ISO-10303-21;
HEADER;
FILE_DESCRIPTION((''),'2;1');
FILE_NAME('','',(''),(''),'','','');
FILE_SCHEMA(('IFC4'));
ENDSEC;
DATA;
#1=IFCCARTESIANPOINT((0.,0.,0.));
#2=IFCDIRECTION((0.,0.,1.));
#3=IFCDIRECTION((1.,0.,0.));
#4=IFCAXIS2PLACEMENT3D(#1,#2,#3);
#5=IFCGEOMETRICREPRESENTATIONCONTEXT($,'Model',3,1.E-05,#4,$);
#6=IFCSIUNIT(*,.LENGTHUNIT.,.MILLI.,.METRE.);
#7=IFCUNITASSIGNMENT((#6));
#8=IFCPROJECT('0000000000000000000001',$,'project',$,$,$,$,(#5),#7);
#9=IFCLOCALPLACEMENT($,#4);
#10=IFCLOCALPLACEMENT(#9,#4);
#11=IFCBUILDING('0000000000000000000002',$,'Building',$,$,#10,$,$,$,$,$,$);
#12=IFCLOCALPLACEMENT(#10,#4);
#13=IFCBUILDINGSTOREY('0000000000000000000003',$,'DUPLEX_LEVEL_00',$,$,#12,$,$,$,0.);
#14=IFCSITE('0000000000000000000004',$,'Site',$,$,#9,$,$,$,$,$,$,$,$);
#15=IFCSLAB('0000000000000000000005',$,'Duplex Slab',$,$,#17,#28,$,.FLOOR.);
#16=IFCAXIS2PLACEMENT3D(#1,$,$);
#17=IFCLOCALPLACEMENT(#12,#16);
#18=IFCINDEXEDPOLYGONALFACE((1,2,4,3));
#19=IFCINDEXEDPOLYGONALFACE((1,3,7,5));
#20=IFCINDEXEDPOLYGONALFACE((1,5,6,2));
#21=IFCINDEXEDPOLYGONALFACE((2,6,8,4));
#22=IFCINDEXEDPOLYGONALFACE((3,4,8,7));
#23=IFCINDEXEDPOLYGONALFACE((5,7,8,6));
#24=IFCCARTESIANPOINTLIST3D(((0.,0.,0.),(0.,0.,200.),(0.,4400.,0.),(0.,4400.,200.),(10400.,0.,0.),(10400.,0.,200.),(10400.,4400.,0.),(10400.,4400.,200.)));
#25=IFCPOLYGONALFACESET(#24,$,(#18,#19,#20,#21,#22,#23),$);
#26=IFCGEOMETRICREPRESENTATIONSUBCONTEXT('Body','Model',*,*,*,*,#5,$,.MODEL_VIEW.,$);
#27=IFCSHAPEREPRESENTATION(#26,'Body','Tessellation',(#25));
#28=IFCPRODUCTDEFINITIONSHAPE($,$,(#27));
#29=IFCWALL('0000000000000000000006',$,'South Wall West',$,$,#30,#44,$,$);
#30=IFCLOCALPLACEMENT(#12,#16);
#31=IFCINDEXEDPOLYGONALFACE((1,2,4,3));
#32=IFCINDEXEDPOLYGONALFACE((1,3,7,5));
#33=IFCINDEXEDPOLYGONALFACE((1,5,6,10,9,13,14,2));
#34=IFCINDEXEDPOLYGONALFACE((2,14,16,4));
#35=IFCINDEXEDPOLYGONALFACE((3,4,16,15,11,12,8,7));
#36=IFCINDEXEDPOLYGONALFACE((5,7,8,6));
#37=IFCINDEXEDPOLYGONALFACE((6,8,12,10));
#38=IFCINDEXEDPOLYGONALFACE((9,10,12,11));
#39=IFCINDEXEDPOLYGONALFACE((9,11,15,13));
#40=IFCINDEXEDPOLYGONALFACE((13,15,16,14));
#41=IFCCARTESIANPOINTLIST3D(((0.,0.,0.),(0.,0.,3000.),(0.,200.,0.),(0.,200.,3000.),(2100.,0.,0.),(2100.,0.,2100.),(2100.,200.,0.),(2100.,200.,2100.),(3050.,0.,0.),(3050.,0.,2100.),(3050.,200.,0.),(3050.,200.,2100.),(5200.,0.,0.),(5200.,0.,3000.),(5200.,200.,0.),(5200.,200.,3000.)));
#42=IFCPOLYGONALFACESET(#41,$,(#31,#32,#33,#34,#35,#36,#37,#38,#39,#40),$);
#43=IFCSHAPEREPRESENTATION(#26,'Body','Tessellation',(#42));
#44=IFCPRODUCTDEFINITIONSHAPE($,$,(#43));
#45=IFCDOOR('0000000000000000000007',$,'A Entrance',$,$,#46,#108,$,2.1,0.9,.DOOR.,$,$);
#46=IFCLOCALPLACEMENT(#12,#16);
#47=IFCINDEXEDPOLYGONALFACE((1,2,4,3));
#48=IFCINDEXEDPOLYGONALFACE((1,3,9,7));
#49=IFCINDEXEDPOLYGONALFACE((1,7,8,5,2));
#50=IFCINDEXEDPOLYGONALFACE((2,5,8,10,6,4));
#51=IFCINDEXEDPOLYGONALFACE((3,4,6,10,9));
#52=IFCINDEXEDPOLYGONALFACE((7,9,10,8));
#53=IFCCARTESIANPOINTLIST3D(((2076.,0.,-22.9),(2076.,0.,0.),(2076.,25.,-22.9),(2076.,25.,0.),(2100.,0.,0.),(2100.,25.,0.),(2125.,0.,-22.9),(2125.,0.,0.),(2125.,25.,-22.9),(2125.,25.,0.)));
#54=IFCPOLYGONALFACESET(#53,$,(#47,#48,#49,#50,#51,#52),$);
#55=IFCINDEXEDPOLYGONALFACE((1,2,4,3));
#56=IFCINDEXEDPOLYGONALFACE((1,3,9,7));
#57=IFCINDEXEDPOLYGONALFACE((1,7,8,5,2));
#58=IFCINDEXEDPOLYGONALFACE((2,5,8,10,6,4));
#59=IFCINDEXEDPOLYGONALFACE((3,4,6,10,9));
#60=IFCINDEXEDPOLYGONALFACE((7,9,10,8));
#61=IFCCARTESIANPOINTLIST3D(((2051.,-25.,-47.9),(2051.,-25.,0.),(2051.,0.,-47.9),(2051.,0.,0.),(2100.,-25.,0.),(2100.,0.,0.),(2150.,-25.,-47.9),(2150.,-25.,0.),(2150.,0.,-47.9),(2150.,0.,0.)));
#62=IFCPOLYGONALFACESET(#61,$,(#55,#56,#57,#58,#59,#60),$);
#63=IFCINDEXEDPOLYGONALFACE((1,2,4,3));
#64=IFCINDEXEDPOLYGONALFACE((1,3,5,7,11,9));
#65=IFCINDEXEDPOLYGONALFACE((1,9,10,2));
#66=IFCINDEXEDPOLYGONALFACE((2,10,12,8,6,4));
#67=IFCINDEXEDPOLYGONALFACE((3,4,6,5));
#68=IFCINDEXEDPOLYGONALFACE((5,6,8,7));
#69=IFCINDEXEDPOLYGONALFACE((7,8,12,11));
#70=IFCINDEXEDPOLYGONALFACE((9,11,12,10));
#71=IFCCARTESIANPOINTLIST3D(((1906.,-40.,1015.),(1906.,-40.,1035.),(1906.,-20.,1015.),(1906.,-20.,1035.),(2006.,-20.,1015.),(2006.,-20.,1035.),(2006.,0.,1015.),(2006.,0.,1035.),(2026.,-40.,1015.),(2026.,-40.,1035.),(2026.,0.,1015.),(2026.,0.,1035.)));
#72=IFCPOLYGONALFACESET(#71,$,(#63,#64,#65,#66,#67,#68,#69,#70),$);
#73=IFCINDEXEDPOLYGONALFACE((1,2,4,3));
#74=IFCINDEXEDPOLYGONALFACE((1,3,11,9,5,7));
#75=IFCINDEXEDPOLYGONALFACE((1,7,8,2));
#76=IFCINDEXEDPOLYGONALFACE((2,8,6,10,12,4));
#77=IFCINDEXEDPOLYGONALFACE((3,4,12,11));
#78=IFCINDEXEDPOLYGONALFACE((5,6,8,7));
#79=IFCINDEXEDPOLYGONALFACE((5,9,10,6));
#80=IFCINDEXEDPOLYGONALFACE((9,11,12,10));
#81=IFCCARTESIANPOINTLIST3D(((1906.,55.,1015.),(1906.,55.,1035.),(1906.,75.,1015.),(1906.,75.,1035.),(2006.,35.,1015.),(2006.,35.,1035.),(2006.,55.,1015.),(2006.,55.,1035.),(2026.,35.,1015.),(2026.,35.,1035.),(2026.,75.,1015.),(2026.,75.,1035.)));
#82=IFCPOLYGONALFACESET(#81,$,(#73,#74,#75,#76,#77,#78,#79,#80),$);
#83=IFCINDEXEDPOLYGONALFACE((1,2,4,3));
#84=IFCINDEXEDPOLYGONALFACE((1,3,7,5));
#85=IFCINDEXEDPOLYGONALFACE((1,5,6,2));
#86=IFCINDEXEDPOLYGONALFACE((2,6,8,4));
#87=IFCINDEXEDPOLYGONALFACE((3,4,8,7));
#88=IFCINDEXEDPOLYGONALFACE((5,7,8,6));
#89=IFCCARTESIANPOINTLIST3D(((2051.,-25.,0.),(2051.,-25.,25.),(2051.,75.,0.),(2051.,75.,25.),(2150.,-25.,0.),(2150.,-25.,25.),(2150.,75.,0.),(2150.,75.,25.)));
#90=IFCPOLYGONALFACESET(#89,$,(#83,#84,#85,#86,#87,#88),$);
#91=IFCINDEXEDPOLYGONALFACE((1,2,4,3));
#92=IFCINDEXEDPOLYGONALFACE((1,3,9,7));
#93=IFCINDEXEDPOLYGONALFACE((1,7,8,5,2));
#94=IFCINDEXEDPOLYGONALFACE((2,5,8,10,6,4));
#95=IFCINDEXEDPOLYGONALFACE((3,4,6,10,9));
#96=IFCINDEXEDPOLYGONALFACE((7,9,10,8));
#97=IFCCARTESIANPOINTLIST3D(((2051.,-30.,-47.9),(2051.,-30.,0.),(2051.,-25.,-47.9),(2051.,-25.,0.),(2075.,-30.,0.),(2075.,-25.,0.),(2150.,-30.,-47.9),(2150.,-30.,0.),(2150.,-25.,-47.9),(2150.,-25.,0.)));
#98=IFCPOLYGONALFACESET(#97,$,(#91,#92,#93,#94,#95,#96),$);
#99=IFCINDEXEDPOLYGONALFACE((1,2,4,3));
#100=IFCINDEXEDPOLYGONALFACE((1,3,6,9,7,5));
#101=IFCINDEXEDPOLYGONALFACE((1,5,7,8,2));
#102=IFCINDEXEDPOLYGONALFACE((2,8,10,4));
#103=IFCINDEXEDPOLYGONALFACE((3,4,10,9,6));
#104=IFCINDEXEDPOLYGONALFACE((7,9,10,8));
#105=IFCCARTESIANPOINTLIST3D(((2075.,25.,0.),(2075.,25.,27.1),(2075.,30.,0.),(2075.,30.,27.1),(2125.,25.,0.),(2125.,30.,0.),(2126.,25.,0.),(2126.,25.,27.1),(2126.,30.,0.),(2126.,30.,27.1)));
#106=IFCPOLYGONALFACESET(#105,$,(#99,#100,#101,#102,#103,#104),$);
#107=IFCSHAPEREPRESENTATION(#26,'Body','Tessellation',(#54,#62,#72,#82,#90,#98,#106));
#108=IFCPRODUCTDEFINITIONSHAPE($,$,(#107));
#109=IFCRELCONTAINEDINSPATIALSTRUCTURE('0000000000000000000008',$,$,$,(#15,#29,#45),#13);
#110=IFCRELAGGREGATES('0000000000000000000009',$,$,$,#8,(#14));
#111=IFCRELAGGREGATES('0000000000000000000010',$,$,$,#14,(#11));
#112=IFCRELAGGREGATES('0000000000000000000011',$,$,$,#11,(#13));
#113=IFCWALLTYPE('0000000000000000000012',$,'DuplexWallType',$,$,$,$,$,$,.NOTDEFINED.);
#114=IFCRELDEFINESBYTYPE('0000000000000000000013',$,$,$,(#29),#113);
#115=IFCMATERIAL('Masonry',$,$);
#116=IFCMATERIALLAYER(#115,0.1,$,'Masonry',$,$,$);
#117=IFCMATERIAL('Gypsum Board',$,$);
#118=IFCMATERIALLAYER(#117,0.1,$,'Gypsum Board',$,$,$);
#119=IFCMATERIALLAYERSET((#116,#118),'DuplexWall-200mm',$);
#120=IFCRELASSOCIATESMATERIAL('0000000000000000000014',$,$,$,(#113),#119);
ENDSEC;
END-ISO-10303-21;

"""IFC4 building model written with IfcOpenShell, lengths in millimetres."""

from ifc_helpers import new_model, si_unit, frame, origin_with_axes, place, context, subcontext, project, spatial, line, indexed_curve, outline, extrude, material, layer, layer_set, type_object, element, fill, save


model = new_model("IFC4")

# Units and contexts
model_context = context("Model", 3, precision=1e-05, world=origin_with_axes())
body_context = subcontext(model_context, "Body", "Model", "MODEL_VIEW")
ifc_project = project(units=[si_unit("LENGTHUNIT", "METRE", prefix="MILLI")], contexts=[model_context])

# Site, building, storey
site_placement = place(None, origin_with_axes())
site = spatial("IfcSite", under=ifc_project, at=site_placement, Name="Site")
building_placement = place(site_placement, origin_with_axes())
building = spatial("IfcBuilding", under=site, at=building_placement, Name="Building")
storey_placement = place(building_placement, origin_with_axes())
storey = spatial("IfcBuildingStorey", under=building, at=storey_placement, Name="DUPLEX_LEVEL_00", Elevation=0.0)

# Slab
slab_placement = place(storey_placement, origin_with_axes())
element("IfcSlab", 1, at=slab_placement, inside=storey, Name="Duplex Slab", PredefinedType="FLOOR", context=body_context, shape_type="SweptSolid", body=[
    extrude(outline(indexed_curve([(0.0, 0.0), (10400.0, 0.0), (10400.0, 4400.0), (0.0, 4400.0), (0.0, 0.0)])), None, (0.0, 0.0, 1.0), 200.0),
])

# Wall, opening, door
ifc_material_1 = material(Name="Masonry")
ifc_layer_1 = layer(ifc_material_1, 0.1, Name="Masonry")
ifc_material_2 = material(Name="Gypsum Board")
ifc_layer_2 = layer(ifc_material_2, 0.1, Name="Gypsum Board")
ifc_layer_set = layer_set([ifc_layer_1, ifc_layer_2], Name="DuplexWall-200mm")
wall_type = type_object("IfcWallType", Name="DuplexWallType", PredefinedType="NOTDEFINED", material=ifc_layer_set)
wall_1_placement = place(storey_placement, origin_with_axes())
wall_1 = element("IfcWall", 2, at=wall_1_placement, inside=storey, type_object=wall_type, Name="South Wall West", context=body_context, shape_type="SweptSolid", body=[
    extrude(outline(indexed_curve([(0.0, 0.0), (0.0, 200.0), (5200.0, 200.0), (5200.0, 0.0), (0.0, 0.0)], self_intersect=False)), origin_with_axes(), (0.0, 0.0, 1.0), 3000.0),
])
opening_1_placement = place(wall_1_placement, frame((2100.0, -25.0, 0.0), z_axis=(0.0, 0.0, 1.0), x_axis=(1.0, 0.0, 0.0)))
opening_1 = element("IfcOpeningElement", 3, at=opening_1_placement, cuts=wall_1, context=body_context, shape_type="SweptSolid", body=[
    extrude(outline(indexed_curve([(0.0, 0.0), (0.0, 250.0), (950.0, 250.0), (950.0, 0.0), (0.0, 0.0)], self_intersect=False)), origin_with_axes(), (0.0, 0.0, 1.0), 2100.0),
])
door_1_placement = place(storey_placement, frame((2100.0, -25.0, 0.0), z_axis=(0.0, 0.0, 1.0), x_axis=(1.0, 0.0, 0.0)))
door_1 = element("IfcDoor", 4, at=door_1_placement, inside=storey, Name="A Entrance", OverallHeight=2.1, OverallWidth=0.9, PredefinedType="DOOR", context=body_context, shape_type="SweptSolid", body=[
    extrude(outline(indexed_curve([(0.0, 0.0), (0.0, 2.1), (0.9, 2.1), (0.9, 0.0), (-24.1, 0.0), (-24.1, -22.9), (25.0, -22.9), (25.0, 0.0)], segments=[line(1, 2, 3, 4, 5, 6, 7, 8, 1)])), frame((0.0, 25.0, 0.0), z_axis=(0.0, -1.0, 0.0), x_axis=(1.0, 0.0, 0.0)), (0.0, 0.0, -1.0), 25.0),
    extrude(outline(indexed_curve([(0.0, 0.0), (0.0, 2.1), (0.9, 2.1), (0.9, 0.0), (-49.0, 0.0), (-49.0, -47.9), (50.0, -47.9), (50.0, 0.0)], segments=[line(1, 2, 3, 4, 5, 6, 7, 8, 1)])), frame((0.0, 0.0, 0.0), z_axis=(0.0, -1.0, 0.0), x_axis=(1.0, 0.0, 0.0)), (0.0, 0.0, -1.0), 25.0),
    extrude(outline(indexed_curve([(0.0, 0.0), (-49.0, 0.0), (-49.0, 35.0), (0.0, 35.0)], segments=[line(1, 2, 3, 4, 1)])), frame((25.0, 25.0, 25.0), z_axis=(0.0, 0.0, 1.0), x_axis=(1.0, 0.0, 0.0)), (0.0, 0.0, 1.0), -47.9),
    extrude(outline(indexed_curve([(0.0, 0.0), (0.0, -40.0), (-120.0, -40.0), (-120.0, -20.0), (-20.0, -20.0), (-20.0, 0.0)], segments=[line(1, 2, 3, 4, 5, 6, 1)])), frame((-74.1, 25.0, 1015.0), z_axis=(0.0, 0.0, 1.0), x_axis=(1.0, 0.0, 0.0)), (0.0, 0.0, 1.0), 20.0),
    extrude(outline(indexed_curve([(0.0, 0.0), (0.0, 40.0), (-120.0, 40.0), (-120.0, 20.0), (-20.0, 20.0), (-20.0, 0.0)], segments=[line(1, 2, 3, 4, 5, 6, 1)])), frame((-74.1, 60.0, 1015.0), z_axis=(0.0, 0.0, 1.0), x_axis=(1.0, 0.0, 0.0)), (0.0, 0.0, 1.0), 20.0),
    extrude(outline(indexed_curve([(0.0, 0.0), (-99.0, 0.0), (-99.0, 100.0), (0.0, 100.0)], segments=[line(1, 2, 3, 4, 1)])), frame((50.0, 0.0, 0.0), z_axis=(0.0, 0.0, 1.0), x_axis=(1.0, 0.0, 0.0)), (0.0, 0.0, 1.0), 25.0),
    extrude(outline(indexed_curve([(0.0, 0.0), (0.0, 27.1), (51.0, 27.1), (51.0, 0.0), (-24.0, 0.0), (-24.0, -47.9), (75.0, -47.9), (75.0, 0.0)], segments=[line(1, 2, 3, 4, 5, 6, 7, 8, 1)])), frame((-25.0, -5.0, 0.0), z_axis=(0.0, -1.0, 0.0), x_axis=(1.0, 0.0, 0.0)), (0.0, 0.0, -1.0), 5.0),
    extrude(outline(indexed_curve([(0.0, 0.0), (0.0, 27.1), (51.0, 27.1), (51.0, 0.0), (1.0, 0.0), (1.0, -22.9), (50.0, -22.9), (50.0, 0.0)], segments=[line(1, 2, 3, 4, 5, 6, 7, 8, 1)])), frame((-25.0, 50.0, 0.0), z_axis=(0.0, -1.0, 0.0), x_axis=(1.0, 0.0, 0.0)), (0.0, 0.0, -1.0), 5.0),
])
fill(opening_1, door_1)

save(model, "model.ifc")
